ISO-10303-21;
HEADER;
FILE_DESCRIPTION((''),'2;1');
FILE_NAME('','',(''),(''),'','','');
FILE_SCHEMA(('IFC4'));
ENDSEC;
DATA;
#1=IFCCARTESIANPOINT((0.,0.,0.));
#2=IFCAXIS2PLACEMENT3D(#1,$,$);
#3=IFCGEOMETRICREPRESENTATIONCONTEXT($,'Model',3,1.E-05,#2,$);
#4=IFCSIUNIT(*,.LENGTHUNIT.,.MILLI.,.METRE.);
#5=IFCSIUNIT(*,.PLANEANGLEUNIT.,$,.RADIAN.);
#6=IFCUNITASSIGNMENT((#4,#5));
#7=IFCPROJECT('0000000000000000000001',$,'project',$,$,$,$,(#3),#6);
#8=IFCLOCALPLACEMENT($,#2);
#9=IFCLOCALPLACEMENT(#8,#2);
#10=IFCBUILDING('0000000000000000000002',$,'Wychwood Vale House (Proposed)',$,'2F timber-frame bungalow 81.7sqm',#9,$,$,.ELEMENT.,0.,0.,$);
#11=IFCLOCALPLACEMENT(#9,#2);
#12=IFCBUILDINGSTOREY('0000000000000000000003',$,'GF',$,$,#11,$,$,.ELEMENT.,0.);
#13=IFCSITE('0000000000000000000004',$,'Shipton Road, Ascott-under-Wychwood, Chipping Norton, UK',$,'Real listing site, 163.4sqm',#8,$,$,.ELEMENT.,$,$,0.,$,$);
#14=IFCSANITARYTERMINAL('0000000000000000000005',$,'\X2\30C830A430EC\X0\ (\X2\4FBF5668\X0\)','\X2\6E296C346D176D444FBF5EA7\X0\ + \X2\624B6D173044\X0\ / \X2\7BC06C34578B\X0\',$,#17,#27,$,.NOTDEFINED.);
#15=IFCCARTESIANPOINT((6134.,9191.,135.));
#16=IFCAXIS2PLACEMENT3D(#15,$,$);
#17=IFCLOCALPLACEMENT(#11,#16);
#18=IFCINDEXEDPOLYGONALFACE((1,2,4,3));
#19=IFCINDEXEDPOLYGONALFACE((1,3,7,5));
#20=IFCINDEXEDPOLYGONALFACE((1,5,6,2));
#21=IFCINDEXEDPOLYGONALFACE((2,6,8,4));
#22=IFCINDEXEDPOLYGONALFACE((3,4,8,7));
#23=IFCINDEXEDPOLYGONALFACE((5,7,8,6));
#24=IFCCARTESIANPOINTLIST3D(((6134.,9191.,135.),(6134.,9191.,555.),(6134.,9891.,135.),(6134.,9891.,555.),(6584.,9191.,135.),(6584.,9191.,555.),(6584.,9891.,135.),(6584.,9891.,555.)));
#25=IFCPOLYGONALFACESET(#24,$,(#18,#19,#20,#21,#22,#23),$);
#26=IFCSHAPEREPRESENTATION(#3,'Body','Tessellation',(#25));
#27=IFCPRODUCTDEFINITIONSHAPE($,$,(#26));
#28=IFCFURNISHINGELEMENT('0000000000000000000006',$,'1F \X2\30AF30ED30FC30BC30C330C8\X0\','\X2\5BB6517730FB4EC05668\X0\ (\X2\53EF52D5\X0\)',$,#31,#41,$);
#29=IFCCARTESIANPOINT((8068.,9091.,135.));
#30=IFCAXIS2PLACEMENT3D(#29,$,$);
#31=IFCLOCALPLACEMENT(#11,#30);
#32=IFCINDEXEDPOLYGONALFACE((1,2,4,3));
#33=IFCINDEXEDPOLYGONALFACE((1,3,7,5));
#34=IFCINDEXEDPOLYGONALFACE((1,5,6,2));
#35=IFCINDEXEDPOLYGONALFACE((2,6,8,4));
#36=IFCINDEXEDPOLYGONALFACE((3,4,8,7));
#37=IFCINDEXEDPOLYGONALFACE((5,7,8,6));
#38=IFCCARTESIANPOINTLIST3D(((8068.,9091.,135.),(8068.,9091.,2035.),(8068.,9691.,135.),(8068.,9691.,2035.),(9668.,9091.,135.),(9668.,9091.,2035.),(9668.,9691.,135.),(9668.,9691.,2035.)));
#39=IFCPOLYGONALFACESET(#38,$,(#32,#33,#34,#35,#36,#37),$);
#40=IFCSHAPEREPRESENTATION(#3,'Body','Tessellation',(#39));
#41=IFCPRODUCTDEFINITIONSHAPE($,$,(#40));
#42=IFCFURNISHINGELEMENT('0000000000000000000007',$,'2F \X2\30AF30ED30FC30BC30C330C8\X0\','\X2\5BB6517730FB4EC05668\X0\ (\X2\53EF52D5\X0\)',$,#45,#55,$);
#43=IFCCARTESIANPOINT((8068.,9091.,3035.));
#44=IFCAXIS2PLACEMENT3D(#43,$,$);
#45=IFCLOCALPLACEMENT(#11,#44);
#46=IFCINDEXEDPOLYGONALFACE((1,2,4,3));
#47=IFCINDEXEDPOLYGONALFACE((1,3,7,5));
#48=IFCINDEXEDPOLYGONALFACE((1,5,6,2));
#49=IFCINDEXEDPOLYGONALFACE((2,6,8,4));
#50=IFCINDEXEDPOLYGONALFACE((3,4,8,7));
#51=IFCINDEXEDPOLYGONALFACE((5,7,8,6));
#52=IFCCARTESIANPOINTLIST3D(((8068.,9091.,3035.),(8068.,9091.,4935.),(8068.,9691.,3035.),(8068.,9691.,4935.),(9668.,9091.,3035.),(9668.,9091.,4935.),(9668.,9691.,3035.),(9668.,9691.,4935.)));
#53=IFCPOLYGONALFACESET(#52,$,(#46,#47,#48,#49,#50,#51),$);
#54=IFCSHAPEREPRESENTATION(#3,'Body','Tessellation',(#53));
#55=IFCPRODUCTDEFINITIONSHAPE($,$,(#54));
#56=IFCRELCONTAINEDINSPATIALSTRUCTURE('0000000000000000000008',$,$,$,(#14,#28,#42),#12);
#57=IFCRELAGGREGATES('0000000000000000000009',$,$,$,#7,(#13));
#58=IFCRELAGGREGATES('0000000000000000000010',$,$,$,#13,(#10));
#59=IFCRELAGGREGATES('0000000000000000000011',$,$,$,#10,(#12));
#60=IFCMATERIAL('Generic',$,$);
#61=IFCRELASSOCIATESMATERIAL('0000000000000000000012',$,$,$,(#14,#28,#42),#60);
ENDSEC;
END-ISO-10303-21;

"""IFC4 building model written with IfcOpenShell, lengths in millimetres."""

from ifc_helpers import new_model, si_unit, frame, frame_2d, origin, place, context, project, spatial, rectangle, extrude, material, element, save


model = new_model("IFC4")

# Units and contexts
model_context = context("Model", 3, precision=1e-05, world=origin())
ifc_project = project(units=[si_unit("LENGTHUNIT", "METRE", prefix="MILLI"), si_unit("PLANEANGLEUNIT", "RADIAN")], contexts=[model_context])

# Site, building, storey
site_placement = place(None, origin())
site = spatial("IfcSite", under=ifc_project, at=site_placement, Name="Shipton Road, Ascott-under-Wychwood, Chipping Norton, UK", ObjectType="Real listing site, 163.4sqm", CompositionType="ELEMENT", RefElevation=0.0)
building_placement = place(site_placement, origin())
building = spatial("IfcBuilding", under=site, at=building_placement, Name="Wychwood Vale House (Proposed)", ObjectType="2F timber-frame bungalow 81.7sqm", CompositionType="ELEMENT", ElevationOfRefHeight=0.0, ElevationOfTerrain=0.0)
storey_placement = place(building_placement, origin())
storey = spatial("IfcBuildingStorey", under=building, at=storey_placement, Name="GF", CompositionType="ELEMENT", Elevation=0.0)

# Shared definitions
ifc_material_1 = material(Name="Generic")

# Sanitary terminal
sanitary_terminal_1_placement = place(storey_placement, frame((6134.0, 9191.0, 135.0)))
element("IfcSanitaryTerminal", 1, at=sanitary_terminal_1_placement, inside=storey, material=ifc_material_1, Name="トイレ (便器)", Description="温水洗浄便座 + 手洗い / 節水型", PredefinedType="NOTDEFINED", context=model_context, shape_type="SweptSolid", body=[
    extrude(rectangle(XDim=450.0, YDim=700.0, at=frame_2d((225.0, 350.0))), frame((6134.0, 9191.0, 135.0)), (0.0, 0.0, 1.0), 420.0),
])

# Furnishing elements
furnishing_1_placement = place(storey_placement, frame((8068.0, 9091.0, 135.0)))
element("IfcFurnishingElement", 2, at=furnishing_1_placement, inside=storey, material=ifc_material_1, Name="1F クローゼット", Description="家具・什器 (可動)", context=model_context, shape_type="SweptSolid", body=[
    extrude(rectangle(XDim=1600.0, YDim=600.0, at=frame_2d((800.0, 300.0))), frame((8068.0, 9091.0, 135.0)), (0.0, 0.0, 1.0), 1900.0),
])
furnishing_2_placement = place(storey_placement, frame((8068.0, 9091.0, 3035.0)))
element("IfcFurnishingElement", 3, at=furnishing_2_placement, inside=storey, material=ifc_material_1, Name="2F クローゼット", Description="家具・什器 (可動)", context=model_context, shape_type="SweptSolid", body=[
    extrude(rectangle(XDim=1600.0, YDim=600.0, at=frame_2d((800.0, 300.0))), frame((8068.0, 9091.0, 3035.0)), (0.0, 0.0, 1.0), 1900.0),
])

save(model, "model.ifc")
